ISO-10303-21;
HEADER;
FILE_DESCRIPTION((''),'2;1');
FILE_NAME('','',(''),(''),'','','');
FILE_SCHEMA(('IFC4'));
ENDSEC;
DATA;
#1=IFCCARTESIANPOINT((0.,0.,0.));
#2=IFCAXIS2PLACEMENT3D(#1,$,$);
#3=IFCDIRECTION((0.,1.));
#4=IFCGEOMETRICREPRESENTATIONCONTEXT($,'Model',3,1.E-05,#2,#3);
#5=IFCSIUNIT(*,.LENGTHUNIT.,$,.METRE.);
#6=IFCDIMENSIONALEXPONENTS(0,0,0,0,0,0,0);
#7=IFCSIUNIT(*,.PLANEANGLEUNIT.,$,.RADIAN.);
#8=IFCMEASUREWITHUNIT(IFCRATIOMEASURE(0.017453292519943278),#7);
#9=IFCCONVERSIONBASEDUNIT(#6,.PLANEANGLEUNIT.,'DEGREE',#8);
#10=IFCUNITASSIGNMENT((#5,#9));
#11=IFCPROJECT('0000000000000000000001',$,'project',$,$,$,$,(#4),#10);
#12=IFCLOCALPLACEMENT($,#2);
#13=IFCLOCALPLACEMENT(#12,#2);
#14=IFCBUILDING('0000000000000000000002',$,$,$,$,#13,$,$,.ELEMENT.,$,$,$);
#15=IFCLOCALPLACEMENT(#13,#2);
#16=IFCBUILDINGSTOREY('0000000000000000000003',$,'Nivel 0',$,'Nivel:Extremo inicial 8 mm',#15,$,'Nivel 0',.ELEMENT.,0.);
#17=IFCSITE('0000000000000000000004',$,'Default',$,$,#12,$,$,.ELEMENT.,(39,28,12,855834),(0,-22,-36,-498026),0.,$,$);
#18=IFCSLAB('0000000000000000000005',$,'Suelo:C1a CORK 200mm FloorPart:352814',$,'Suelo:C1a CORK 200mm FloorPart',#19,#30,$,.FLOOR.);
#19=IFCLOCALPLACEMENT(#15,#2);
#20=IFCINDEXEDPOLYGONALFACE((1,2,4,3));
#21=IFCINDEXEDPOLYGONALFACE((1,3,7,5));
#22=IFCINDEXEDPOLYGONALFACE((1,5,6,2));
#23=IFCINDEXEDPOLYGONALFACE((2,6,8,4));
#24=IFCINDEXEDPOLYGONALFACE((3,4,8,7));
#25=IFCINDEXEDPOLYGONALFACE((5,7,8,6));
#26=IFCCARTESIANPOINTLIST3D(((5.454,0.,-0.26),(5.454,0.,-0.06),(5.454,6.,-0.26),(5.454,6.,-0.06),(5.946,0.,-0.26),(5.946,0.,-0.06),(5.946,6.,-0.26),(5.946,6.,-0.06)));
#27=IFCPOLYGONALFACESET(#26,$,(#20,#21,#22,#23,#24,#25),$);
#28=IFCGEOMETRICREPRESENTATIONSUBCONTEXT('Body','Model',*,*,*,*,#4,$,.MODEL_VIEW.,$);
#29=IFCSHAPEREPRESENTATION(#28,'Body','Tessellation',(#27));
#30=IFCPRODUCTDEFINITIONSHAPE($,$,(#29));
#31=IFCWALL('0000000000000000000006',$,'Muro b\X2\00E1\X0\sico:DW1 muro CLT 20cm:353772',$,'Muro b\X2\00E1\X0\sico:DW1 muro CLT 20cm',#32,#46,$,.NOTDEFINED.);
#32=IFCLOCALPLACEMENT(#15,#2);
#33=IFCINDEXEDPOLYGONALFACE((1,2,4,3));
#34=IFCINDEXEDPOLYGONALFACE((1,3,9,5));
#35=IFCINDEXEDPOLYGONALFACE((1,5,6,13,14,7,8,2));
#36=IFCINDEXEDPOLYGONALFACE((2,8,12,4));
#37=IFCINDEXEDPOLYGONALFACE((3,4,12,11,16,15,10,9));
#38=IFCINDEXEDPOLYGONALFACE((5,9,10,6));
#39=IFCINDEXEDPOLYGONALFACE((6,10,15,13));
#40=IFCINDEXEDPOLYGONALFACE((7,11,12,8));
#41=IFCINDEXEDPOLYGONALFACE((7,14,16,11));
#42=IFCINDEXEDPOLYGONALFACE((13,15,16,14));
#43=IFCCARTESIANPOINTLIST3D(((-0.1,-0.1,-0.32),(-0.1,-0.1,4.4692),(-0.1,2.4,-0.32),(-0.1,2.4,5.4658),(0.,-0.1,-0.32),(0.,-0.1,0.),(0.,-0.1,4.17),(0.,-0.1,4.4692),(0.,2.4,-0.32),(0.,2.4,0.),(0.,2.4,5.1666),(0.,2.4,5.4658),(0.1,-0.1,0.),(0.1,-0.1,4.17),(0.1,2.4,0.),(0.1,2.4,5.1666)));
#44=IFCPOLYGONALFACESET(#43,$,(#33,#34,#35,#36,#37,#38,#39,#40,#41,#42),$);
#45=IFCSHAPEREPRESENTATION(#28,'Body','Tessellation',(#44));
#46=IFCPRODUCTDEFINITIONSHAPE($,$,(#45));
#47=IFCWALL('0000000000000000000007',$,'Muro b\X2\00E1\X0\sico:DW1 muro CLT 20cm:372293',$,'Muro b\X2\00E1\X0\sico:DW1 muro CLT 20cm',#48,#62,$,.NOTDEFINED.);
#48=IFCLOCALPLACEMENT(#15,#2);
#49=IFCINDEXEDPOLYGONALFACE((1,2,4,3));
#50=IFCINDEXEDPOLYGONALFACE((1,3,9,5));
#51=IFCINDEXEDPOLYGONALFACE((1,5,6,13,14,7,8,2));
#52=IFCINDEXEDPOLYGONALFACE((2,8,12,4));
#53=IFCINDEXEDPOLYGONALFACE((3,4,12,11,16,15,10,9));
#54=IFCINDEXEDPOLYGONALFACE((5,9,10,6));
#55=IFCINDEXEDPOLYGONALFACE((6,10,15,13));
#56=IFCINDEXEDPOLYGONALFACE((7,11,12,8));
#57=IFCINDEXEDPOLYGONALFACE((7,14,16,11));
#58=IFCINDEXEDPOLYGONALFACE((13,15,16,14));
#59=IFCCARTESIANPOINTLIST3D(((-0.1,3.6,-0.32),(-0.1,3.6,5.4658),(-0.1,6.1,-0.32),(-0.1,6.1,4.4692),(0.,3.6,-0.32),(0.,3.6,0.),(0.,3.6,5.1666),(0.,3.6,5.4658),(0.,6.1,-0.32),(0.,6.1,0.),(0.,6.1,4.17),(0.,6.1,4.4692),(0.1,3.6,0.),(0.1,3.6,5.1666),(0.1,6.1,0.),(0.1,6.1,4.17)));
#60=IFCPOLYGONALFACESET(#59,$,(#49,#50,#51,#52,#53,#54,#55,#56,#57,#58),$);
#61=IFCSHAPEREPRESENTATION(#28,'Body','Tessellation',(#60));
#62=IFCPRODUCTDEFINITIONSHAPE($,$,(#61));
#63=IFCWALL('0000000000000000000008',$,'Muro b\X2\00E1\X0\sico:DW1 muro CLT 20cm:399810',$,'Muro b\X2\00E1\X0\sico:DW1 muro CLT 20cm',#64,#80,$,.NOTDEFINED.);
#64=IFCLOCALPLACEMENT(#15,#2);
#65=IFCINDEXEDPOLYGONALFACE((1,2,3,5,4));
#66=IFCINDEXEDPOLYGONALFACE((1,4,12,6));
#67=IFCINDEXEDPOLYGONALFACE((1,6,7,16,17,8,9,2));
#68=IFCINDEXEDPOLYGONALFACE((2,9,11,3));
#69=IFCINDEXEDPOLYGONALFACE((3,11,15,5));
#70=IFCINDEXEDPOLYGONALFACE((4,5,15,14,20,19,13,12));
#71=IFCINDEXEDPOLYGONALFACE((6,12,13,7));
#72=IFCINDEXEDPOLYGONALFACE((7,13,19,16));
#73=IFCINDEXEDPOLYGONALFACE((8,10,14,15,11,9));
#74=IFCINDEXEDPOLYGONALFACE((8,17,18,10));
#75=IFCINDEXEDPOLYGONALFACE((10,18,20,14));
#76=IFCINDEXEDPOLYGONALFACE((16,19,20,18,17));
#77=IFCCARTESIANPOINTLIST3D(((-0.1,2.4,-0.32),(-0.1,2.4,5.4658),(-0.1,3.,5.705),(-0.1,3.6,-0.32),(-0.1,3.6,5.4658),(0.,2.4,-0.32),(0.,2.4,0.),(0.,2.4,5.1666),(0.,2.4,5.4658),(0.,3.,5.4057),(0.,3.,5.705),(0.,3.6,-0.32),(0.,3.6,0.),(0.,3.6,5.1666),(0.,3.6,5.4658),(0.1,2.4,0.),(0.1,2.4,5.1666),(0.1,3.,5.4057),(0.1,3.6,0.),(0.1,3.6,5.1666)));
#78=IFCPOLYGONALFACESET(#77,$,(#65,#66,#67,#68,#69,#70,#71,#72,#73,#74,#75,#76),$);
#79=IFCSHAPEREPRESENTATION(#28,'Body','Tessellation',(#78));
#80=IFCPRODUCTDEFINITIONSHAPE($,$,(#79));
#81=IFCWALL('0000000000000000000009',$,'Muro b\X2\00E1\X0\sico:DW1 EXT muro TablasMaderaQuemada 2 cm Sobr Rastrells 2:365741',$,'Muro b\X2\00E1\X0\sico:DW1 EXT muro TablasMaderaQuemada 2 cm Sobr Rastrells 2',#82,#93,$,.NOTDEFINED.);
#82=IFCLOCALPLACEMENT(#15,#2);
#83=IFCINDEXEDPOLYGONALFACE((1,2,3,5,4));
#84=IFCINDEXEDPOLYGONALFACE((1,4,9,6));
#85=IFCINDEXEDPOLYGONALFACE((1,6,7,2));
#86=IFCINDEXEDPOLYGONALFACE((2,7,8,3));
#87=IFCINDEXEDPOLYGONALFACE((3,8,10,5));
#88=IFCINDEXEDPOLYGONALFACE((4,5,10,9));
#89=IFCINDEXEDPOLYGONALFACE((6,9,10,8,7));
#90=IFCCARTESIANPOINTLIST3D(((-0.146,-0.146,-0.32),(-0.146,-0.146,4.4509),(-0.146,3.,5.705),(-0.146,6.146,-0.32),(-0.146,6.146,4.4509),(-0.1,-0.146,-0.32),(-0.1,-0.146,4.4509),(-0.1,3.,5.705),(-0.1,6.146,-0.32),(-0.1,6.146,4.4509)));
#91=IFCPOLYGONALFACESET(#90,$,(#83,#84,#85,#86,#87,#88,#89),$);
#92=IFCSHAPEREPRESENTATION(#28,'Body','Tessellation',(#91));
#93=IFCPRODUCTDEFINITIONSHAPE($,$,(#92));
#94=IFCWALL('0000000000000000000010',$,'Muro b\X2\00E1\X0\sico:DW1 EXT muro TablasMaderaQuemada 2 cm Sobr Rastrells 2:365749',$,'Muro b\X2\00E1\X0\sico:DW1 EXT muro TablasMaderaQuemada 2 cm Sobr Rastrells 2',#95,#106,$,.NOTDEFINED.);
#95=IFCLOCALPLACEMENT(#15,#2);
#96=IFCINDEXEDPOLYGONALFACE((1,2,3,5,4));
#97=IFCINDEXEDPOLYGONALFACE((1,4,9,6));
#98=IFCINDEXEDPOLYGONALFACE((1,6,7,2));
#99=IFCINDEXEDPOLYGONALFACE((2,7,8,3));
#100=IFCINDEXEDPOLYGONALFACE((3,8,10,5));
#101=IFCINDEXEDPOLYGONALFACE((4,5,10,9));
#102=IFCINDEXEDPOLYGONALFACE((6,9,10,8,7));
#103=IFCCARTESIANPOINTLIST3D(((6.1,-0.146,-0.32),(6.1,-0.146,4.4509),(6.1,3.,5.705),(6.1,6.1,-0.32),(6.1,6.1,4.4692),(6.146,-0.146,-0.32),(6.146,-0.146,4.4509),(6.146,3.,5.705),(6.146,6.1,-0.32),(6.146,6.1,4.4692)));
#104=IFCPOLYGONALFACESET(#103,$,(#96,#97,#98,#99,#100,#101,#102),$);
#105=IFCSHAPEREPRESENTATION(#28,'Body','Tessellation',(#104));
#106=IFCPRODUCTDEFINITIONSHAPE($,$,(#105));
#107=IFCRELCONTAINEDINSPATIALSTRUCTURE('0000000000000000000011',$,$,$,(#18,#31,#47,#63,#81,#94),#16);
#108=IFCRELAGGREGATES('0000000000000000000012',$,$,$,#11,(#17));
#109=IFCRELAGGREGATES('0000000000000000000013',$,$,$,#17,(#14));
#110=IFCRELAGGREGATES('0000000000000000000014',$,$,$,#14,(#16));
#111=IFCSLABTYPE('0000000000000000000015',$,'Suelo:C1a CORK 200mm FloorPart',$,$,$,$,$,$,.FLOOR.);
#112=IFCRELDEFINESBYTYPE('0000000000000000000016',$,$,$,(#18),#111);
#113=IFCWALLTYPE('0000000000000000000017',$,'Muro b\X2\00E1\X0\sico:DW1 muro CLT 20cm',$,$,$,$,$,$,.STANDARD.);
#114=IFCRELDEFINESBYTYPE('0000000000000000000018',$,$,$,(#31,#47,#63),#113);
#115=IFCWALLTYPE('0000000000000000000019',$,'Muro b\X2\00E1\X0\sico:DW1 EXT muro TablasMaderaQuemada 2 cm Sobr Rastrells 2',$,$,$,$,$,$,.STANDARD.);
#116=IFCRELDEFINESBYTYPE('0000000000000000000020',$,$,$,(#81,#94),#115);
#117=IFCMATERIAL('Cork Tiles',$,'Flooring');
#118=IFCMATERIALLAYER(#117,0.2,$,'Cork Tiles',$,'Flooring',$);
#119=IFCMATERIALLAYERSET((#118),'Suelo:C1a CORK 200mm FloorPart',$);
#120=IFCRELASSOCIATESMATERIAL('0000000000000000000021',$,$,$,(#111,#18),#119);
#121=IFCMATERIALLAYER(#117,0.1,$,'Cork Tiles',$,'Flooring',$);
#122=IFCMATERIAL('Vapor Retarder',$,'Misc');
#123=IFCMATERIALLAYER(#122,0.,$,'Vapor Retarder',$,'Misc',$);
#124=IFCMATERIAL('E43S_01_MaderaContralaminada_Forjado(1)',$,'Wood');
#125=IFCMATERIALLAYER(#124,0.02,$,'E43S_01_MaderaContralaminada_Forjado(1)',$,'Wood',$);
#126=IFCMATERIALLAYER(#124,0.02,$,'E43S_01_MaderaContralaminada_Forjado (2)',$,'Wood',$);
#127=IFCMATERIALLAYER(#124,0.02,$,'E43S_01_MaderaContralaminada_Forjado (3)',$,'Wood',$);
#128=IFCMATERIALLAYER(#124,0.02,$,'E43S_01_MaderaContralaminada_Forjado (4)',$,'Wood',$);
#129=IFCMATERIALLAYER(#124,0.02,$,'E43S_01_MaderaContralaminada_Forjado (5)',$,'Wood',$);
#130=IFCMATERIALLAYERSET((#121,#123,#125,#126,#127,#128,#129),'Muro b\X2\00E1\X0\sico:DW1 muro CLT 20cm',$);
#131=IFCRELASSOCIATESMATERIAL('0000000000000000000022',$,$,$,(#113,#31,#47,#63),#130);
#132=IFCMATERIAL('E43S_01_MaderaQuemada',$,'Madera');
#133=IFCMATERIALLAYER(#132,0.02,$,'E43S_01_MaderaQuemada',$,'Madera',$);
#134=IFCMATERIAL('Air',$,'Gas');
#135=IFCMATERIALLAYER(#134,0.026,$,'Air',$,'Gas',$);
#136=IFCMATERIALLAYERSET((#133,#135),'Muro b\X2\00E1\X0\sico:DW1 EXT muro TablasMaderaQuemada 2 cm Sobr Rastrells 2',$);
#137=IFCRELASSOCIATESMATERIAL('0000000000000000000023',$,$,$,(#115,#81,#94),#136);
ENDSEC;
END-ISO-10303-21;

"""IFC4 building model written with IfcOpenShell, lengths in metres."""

from ifc_helpers import new_model, entity, si_unit, converted_unit, direction, frame, frame_2d, origin, place, context, subcontext, project, spatial, polyline, rectangle, extrude, clip, bounded_halfspace, material, layer, layer_set, layer_usage, type_object, element, save


model = new_model("IFC4")

# Units and contexts
model_context = context("Model", 3, precision=1e-05, world=origin(), true_north=direction((0.0, 1.0)))
body_context = subcontext(model_context, "Body", "Model", "MODEL_VIEW")
ifc_project = project(units=[si_unit("LENGTHUNIT", "METRE"), converted_unit("PLANEANGLEUNIT", "DEGREE", entity("IfcRatioMeasure", 0.017453292519943278), si_unit("PLANEANGLEUNIT", "RADIAN"), dimensions=[0, 0, 0, 0, 0, 0, 0])], contexts=[model_context])

# Site, building, storey
site_placement = place(None, origin())
site = spatial("IfcSite", under=ifc_project, at=site_placement, Name="Default", CompositionType="ELEMENT", RefLatitude=(39, 28, 12, 855834), RefLongitude=(0, -22, -36, -498026), RefElevation=0.0)
building_placement = place(site_placement, origin())
building = spatial("IfcBuilding", under=site, at=building_placement, CompositionType="ELEMENT")
storey_placement = place(building_placement, origin())
storey = spatial("IfcBuildingStorey", under=building, at=storey_placement, Name="Nivel 0", ObjectType="Nivel:Extremo inicial 8 mm", LongName="Nivel 0", CompositionType="ELEMENT", Elevation=0.0)

# Slab
ifc_material_1 = material(Name="E43S_01_MaderaContralaminada_Forjado(1)", Category="Wood")
ifc_material_2 = material(Name="Cork Tiles", Category="Flooring")
ifc_layer_1 = layer(ifc_material_2, 0.2, Name="Cork Tiles", Category="Flooring")
ifc_layer_set_1 = layer_set([ifc_layer_1], Name="Suelo:C1a CORK 200mm FloorPart")
ifc_layer_usage_1 = layer_usage(ifc_layer_set_1, "AXIS3", "POSITIVE", 0.0)
slab_type_1 = type_object("IfcSlabType", Name="Suelo:C1a CORK 200mm FloorPart", PredefinedType="FLOOR", material=ifc_layer_set_1)
slab_1_placement = place(storey_placement, origin())
element("IfcSlab", 1, at=slab_1_placement, inside=storey, type_object=slab_type_1, material=ifc_layer_usage_1, Name="Suelo:C1a CORK 200mm FloorPart:352814", ObjectType="Suelo:C1a CORK 200mm FloorPart", PredefinedType="FLOOR", context=body_context, shape_type="SweptSolid", body=[
    extrude(rectangle(XDim=6.0, YDim=0.492, at=frame_2d((0.0, 0.0), x_axis=(1.0, 0.0))), frame((5.7, 3.0, -0.06), z_axis=(0.0, 0.0, -1.0), x_axis=(0.0, 1.0, 0.0)), (0.0, 0.0, 1.0), 0.2),
])

# Walls
ifc_layer_2 = layer(ifc_material_2, 0.1, Name="Cork Tiles", Category="Flooring")
ifc_material_3 = material(Name="Vapor Retarder", Category="Misc")
ifc_layer_3 = layer(ifc_material_3, 0.0, Name="Vapor Retarder", Category="Misc")
ifc_layer_4 = layer(ifc_material_1, 0.02, Name="E43S_01_MaderaContralaminada_Forjado(1)", Category="Wood")
ifc_layer_5 = layer(ifc_material_1, 0.02, Name="E43S_01_MaderaContralaminada_Forjado (2)", Category="Wood")
ifc_layer_6 = layer(ifc_material_1, 0.02, Name="E43S_01_MaderaContralaminada_Forjado (3)", Category="Wood")
ifc_layer_7 = layer(ifc_material_1, 0.02, Name="E43S_01_MaderaContralaminada_Forjado (4)", Category="Wood")
ifc_layer_8 = layer(ifc_material_1, 0.02, Name="E43S_01_MaderaContralaminada_Forjado (5)", Category="Wood")
ifc_layer_set_2 = layer_set([ifc_layer_2, ifc_layer_3, ifc_layer_4, ifc_layer_5, ifc_layer_6, ifc_layer_7, ifc_layer_8], Name="Muro básico:DW1 muro CLT 20cm")
ifc_layer_usage_2 = layer_usage(ifc_layer_set_2, "AXIS2", "NEGATIVE", 0.1)
wall_type_1 = type_object("IfcWallType", Name="Muro básico:DW1 muro CLT 20cm", PredefinedType="STANDARD", material=ifc_layer_set_2)
wall_1_placement = place(storey_placement, frame((0.0, -0.1, -0.32), z_axis=(0.0, 0.0, 1.0), x_axis=(0.0, 1.0, 0.0)))
element("IfcWall", 2, at=wall_1_placement, inside=storey, type_object=wall_type_1, material=ifc_layer_usage_2, Name="Muro básico:DW1 muro CLT 20cm:353772", ObjectType="Muro básico:DW1 muro CLT 20cm", PredefinedType="NOTDEFINED", context=body_context, shape_type="Clipping", body=[
    clip(clip(clip(extrude(rectangle(XDim=2.5, YDim=0.2, at=frame_2d((1.25, 0.0), x_axis=(-1.0, 0.0))), origin(), (0.0, 0.0, 1.0), 5.7858), bounded_halfspace(frame((0.0, -0.1, 4.49), z_axis=(-0.370288, 0.0, 0.928917), x_axis=(0.0, -1.0, 0.0)), False, frame((0.0, -0.1, 4.49)), polyline([(0.0, 0.0), (0.2, 0.0), (2.5, 0.0), (2.5, 0.1), (0.0, 0.1), (0.0, 0.0)]))), bounded_halfspace(frame((2.5, 0.0, 5.7858), z_axis=(-0.370288, 0.0, 0.928917), x_axis=(0.0, -1.0, 0.0)), False, frame((2.5, 0.0, 5.7858)), polyline([(0.0, 0.0), (0.0, 0.1), (-2.5, 0.1), (-2.5, 0.0), (0.0, 0.0)]))), bounded_halfspace(frame((2.5, -0.1, 0.32), z_axis=(0.0, 0.0, -1.0), x_axis=(0.0, 1.0, 0.0)), False, frame((2.5, -0.1, 0.32)), polyline([(0.0, 0.0), (0.0, 0.1), (-2.5, 0.1), (-2.5, 0.0), (-2.4, 0.0), (-2.3, 0.0), (0.0, 0.0)]))),
])
ifc_layer_usage_3 = layer_usage(ifc_layer_set_2, "AXIS2", "NEGATIVE", 0.1)
wall_2_placement = place(storey_placement, frame((0.0, 3.6, -0.32), z_axis=(0.0, 0.0, 1.0), x_axis=(0.0, 1.0, 0.0)))
element("IfcWall", 3, at=wall_2_placement, inside=storey, type_object=wall_type_1, material=ifc_layer_usage_3, Name="Muro básico:DW1 muro CLT 20cm:372293", ObjectType="Muro básico:DW1 muro CLT 20cm", PredefinedType="NOTDEFINED", context=body_context, shape_type="Clipping", body=[
    clip(clip(clip(extrude(rectangle(XDim=2.5, YDim=0.2, at=frame_2d((1.25, 0.0), x_axis=(-1.0, 0.0))), origin(), (0.0, 0.0, 1.0), 5.7858), bounded_halfspace(frame((0.0, -0.1, 5.4866), z_axis=(0.370288, 0.0, 0.928917), x_axis=(0.0, 1.0, 0.0)), False, frame((0.0, -0.1, 5.4866)), polyline([(0.0, 0.0), (2.3, 0.0), (2.5, 0.0), (2.5, 0.1), (0.0, 0.1), (0.0, 0.0)]))), bounded_halfspace(frame((2.5, 0.0, 4.7892), z_axis=(0.370288, 0.0, 0.928917), x_axis=(0.0, 1.0, 0.0)), False, frame((2.5, 0.0, 4.7892)), polyline([(0.0, 0.0), (0.0, 0.1), (-2.5, 0.1), (-2.5, 0.0), (0.0, 0.0)]))), bounded_halfspace(frame((2.5, -0.1, 0.32), z_axis=(0.0, 0.0, -1.0), x_axis=(0.0, 1.0, 0.0)), False, frame((2.5, -0.1, 0.32)), polyline([(0.0, 0.0), (0.0, 0.1), (-2.5, 0.1), (-2.5, 0.0), (-0.2, 0.0), (-0.1, 0.0), (0.0, 0.0)]))),
])
ifc_layer_usage_4 = layer_usage(ifc_layer_set_2, "AXIS2", "NEGATIVE", 0.1)
wall_3_placement = place(storey_placement, frame((0.0, 2.4, -0.32), z_axis=(0.0, 0.0, 1.0), x_axis=(0.0, 1.0, 0.0)))
element("IfcWall", 4, at=wall_3_placement, inside=storey, type_object=wall_type_1, material=ifc_layer_usage_4, Name="Muro básico:DW1 muro CLT 20cm:399810", ObjectType="Muro básico:DW1 muro CLT 20cm", PredefinedType="NOTDEFINED", context=body_context, shape_type="Clipping", body=[
    clip(clip(clip(clip(clip(extrude(rectangle(XDim=1.2, YDim=0.2, at=frame_2d((0.6, 0.0), x_axis=(-1.0, 0.0))), origin(), (0.0, 0.0, 1.0), 6.025), bounded_halfspace(frame((0.0, -0.1, 5.4866), z_axis=(-0.370288, 0.0, 0.928917), x_axis=(0.0, -1.0, 0.0)), False, frame((0.0, -0.1, 5.4866)), polyline([(0.0, 0.0), (0.6, 0.0), (0.6, 0.1), (0.0, 0.1), (0.0, 0.0)]))), bounded_halfspace(frame((0.6, -0.1, 5.7257), z_axis=(0.370288, 0.0, 0.928917), x_axis=(0.0, 1.0, 0.0)), False, frame((0.6, -0.1, 5.7257)), polyline([(0.0, 0.0), (0.6, 0.0), (0.6, 0.1), (0.0, 0.1), (0.0, 0.0)]))), bounded_halfspace(frame((1.2, 0.0, 5.7858), z_axis=(0.370288, 0.0, 0.928917), x_axis=(0.0, 1.0, 0.0)), False, frame((1.2, 0.0, 5.7858)), polyline([(0.0, 0.0), (0.0, 0.1), (-0.6, 0.1), (-0.6, 0.0), (0.0, 0.0)]))), bounded_halfspace(frame((0.6, 0.1, 6.025), z_axis=(-0.370288, 0.0, 0.928917), x_axis=(0.0, -1.0, 0.0)), False, frame((0.6, 0.1, 6.025)), polyline([(0.0, 0.0), (-0.6, 0.0), (-0.6, -0.1), (0.0, -0.1), (0.0, 0.0)]))), bounded_halfspace(frame((1.2, -0.1, 0.32), z_axis=(0.0, 0.0, -1.0), x_axis=(0.0, 1.0, 0.0)), False, frame((1.2, -0.1, 0.32)), polyline([(0.0, 0.0), (0.0, 0.1), (-1.2, 0.1), (-1.2, 0.0), (0.0, 0.0)]))),
])
ifc_material_4 = material(Name="E43S_01_MaderaQuemada", Category="Madera")
ifc_layer_9 = layer(ifc_material_4, 0.02, Name="E43S_01_MaderaQuemada", Category="Madera")
ifc_material_5 = material(Name="Air", Category="Gas")
ifc_layer_10 = layer(ifc_material_5, 0.026, Name="Air", Category="Gas")
ifc_layer_set_3 = layer_set([ifc_layer_9, ifc_layer_10], Name="Muro básico:DW1 EXT muro TablasMaderaQuemada 2 cm Sobr Rastrells 2")
ifc_layer_usage_5 = layer_usage(ifc_layer_set_3, "AXIS2", "NEGATIVE", 0.023)
wall_type_2 = type_object("IfcWallType", Name="Muro básico:DW1 EXT muro TablasMaderaQuemada 2 cm Sobr Rastrells 2", PredefinedType="STANDARD", material=ifc_layer_set_3)
wall_4_placement = place(storey_placement, frame((-0.123, -0.146, -0.32), z_axis=(0.0, 0.0, 1.0), x_axis=(0.0, 1.0, 0.0)))
element("IfcWall", 5, at=wall_4_placement, inside=storey, type_object=wall_type_2, material=ifc_layer_usage_5, Name="Muro básico:DW1 EXT muro TablasMaderaQuemada 2 cm Sobr Rastrells 2:365741", ObjectType="Muro básico:DW1 EXT muro TablasMaderaQuemada 2 cm Sobr Rastrells 2", PredefinedType="NOTDEFINED", context=body_context, shape_type="Clipping", body=[
    clip(clip(extrude(rectangle(XDim=6.292, YDim=0.046, at=frame_2d((3.146, 0.0), x_axis=(-1.0, 0.0))), origin(), (0.0, 0.0, 1.0), 6.025), bounded_halfspace(frame((0.0, -0.023, 4.7709), z_axis=(-0.370288, 0.0, 0.928917), x_axis=(0.0, -1.0, 0.0)), False, frame((0.0, -0.023, 4.7709)), polyline([(0.0, 0.0), (0.046, 0.0), (3.146, 0.0), (3.146, 0.046), (0.0, 0.046), (0.0, 0.0)]))), bounded_halfspace(frame((3.146, -0.023, 6.025), z_axis=(0.370288, 0.0, 0.928917), x_axis=(0.0, 1.0, 0.0)), False, frame((3.146, -0.023, 6.025)), polyline([(0.0, 0.0), (3.1, 0.0), (3.146, 0.0), (3.146, 0.046), (0.0, 0.046), (0.0, 0.0)]))),
])
ifc_layer_usage_6 = layer_usage(ifc_layer_set_3, "AXIS2", "NEGATIVE", 0.023)
wall_5_placement = place(storey_placement, frame((6.123, 6.1, -0.32), z_axis=(0.0, 0.0, 1.0), x_axis=(0.0, -1.0, 0.0)))
element("IfcWall", 6, at=wall_5_placement, inside=storey, type_object=wall_type_2, material=ifc_layer_usage_6, Name="Muro básico:DW1 EXT muro TablasMaderaQuemada 2 cm Sobr Rastrells 2:365749", ObjectType="Muro básico:DW1 EXT muro TablasMaderaQuemada 2 cm Sobr Rastrells 2", PredefinedType="NOTDEFINED", context=body_context, shape_type="Clipping", body=[
    clip(clip(extrude(rectangle(XDim=6.246, YDim=0.046, at=frame_2d((3.123, 0.0), x_axis=(-1.0, 0.0))), origin(), (0.0, 0.0, 1.0), 6.025), bounded_halfspace(frame((0.0, -0.023, 4.7892), z_axis=(-0.370288, 0.0, 0.928917), x_axis=(0.0, -1.0, 0.0)), False, frame((0.0, -0.023, 4.7892)), polyline([(0.0, 0.0), (3.1, 0.0), (3.1, 0.046), (0.0, 0.046), (0.0, 0.0)]))), bounded_halfspace(frame((3.1, -0.023, 6.025), z_axis=(0.370288, 0.0, 0.928917), x_axis=(0.0, 1.0, 0.0)), False, frame((3.1, -0.023, 6.025)), polyline([(0.0, 0.0), (3.1, 0.0), (3.146, 0.0), (3.146, 0.046), (0.0, 0.046), (0.0, 0.0)]))),
])

save(model, "model.ifc")
